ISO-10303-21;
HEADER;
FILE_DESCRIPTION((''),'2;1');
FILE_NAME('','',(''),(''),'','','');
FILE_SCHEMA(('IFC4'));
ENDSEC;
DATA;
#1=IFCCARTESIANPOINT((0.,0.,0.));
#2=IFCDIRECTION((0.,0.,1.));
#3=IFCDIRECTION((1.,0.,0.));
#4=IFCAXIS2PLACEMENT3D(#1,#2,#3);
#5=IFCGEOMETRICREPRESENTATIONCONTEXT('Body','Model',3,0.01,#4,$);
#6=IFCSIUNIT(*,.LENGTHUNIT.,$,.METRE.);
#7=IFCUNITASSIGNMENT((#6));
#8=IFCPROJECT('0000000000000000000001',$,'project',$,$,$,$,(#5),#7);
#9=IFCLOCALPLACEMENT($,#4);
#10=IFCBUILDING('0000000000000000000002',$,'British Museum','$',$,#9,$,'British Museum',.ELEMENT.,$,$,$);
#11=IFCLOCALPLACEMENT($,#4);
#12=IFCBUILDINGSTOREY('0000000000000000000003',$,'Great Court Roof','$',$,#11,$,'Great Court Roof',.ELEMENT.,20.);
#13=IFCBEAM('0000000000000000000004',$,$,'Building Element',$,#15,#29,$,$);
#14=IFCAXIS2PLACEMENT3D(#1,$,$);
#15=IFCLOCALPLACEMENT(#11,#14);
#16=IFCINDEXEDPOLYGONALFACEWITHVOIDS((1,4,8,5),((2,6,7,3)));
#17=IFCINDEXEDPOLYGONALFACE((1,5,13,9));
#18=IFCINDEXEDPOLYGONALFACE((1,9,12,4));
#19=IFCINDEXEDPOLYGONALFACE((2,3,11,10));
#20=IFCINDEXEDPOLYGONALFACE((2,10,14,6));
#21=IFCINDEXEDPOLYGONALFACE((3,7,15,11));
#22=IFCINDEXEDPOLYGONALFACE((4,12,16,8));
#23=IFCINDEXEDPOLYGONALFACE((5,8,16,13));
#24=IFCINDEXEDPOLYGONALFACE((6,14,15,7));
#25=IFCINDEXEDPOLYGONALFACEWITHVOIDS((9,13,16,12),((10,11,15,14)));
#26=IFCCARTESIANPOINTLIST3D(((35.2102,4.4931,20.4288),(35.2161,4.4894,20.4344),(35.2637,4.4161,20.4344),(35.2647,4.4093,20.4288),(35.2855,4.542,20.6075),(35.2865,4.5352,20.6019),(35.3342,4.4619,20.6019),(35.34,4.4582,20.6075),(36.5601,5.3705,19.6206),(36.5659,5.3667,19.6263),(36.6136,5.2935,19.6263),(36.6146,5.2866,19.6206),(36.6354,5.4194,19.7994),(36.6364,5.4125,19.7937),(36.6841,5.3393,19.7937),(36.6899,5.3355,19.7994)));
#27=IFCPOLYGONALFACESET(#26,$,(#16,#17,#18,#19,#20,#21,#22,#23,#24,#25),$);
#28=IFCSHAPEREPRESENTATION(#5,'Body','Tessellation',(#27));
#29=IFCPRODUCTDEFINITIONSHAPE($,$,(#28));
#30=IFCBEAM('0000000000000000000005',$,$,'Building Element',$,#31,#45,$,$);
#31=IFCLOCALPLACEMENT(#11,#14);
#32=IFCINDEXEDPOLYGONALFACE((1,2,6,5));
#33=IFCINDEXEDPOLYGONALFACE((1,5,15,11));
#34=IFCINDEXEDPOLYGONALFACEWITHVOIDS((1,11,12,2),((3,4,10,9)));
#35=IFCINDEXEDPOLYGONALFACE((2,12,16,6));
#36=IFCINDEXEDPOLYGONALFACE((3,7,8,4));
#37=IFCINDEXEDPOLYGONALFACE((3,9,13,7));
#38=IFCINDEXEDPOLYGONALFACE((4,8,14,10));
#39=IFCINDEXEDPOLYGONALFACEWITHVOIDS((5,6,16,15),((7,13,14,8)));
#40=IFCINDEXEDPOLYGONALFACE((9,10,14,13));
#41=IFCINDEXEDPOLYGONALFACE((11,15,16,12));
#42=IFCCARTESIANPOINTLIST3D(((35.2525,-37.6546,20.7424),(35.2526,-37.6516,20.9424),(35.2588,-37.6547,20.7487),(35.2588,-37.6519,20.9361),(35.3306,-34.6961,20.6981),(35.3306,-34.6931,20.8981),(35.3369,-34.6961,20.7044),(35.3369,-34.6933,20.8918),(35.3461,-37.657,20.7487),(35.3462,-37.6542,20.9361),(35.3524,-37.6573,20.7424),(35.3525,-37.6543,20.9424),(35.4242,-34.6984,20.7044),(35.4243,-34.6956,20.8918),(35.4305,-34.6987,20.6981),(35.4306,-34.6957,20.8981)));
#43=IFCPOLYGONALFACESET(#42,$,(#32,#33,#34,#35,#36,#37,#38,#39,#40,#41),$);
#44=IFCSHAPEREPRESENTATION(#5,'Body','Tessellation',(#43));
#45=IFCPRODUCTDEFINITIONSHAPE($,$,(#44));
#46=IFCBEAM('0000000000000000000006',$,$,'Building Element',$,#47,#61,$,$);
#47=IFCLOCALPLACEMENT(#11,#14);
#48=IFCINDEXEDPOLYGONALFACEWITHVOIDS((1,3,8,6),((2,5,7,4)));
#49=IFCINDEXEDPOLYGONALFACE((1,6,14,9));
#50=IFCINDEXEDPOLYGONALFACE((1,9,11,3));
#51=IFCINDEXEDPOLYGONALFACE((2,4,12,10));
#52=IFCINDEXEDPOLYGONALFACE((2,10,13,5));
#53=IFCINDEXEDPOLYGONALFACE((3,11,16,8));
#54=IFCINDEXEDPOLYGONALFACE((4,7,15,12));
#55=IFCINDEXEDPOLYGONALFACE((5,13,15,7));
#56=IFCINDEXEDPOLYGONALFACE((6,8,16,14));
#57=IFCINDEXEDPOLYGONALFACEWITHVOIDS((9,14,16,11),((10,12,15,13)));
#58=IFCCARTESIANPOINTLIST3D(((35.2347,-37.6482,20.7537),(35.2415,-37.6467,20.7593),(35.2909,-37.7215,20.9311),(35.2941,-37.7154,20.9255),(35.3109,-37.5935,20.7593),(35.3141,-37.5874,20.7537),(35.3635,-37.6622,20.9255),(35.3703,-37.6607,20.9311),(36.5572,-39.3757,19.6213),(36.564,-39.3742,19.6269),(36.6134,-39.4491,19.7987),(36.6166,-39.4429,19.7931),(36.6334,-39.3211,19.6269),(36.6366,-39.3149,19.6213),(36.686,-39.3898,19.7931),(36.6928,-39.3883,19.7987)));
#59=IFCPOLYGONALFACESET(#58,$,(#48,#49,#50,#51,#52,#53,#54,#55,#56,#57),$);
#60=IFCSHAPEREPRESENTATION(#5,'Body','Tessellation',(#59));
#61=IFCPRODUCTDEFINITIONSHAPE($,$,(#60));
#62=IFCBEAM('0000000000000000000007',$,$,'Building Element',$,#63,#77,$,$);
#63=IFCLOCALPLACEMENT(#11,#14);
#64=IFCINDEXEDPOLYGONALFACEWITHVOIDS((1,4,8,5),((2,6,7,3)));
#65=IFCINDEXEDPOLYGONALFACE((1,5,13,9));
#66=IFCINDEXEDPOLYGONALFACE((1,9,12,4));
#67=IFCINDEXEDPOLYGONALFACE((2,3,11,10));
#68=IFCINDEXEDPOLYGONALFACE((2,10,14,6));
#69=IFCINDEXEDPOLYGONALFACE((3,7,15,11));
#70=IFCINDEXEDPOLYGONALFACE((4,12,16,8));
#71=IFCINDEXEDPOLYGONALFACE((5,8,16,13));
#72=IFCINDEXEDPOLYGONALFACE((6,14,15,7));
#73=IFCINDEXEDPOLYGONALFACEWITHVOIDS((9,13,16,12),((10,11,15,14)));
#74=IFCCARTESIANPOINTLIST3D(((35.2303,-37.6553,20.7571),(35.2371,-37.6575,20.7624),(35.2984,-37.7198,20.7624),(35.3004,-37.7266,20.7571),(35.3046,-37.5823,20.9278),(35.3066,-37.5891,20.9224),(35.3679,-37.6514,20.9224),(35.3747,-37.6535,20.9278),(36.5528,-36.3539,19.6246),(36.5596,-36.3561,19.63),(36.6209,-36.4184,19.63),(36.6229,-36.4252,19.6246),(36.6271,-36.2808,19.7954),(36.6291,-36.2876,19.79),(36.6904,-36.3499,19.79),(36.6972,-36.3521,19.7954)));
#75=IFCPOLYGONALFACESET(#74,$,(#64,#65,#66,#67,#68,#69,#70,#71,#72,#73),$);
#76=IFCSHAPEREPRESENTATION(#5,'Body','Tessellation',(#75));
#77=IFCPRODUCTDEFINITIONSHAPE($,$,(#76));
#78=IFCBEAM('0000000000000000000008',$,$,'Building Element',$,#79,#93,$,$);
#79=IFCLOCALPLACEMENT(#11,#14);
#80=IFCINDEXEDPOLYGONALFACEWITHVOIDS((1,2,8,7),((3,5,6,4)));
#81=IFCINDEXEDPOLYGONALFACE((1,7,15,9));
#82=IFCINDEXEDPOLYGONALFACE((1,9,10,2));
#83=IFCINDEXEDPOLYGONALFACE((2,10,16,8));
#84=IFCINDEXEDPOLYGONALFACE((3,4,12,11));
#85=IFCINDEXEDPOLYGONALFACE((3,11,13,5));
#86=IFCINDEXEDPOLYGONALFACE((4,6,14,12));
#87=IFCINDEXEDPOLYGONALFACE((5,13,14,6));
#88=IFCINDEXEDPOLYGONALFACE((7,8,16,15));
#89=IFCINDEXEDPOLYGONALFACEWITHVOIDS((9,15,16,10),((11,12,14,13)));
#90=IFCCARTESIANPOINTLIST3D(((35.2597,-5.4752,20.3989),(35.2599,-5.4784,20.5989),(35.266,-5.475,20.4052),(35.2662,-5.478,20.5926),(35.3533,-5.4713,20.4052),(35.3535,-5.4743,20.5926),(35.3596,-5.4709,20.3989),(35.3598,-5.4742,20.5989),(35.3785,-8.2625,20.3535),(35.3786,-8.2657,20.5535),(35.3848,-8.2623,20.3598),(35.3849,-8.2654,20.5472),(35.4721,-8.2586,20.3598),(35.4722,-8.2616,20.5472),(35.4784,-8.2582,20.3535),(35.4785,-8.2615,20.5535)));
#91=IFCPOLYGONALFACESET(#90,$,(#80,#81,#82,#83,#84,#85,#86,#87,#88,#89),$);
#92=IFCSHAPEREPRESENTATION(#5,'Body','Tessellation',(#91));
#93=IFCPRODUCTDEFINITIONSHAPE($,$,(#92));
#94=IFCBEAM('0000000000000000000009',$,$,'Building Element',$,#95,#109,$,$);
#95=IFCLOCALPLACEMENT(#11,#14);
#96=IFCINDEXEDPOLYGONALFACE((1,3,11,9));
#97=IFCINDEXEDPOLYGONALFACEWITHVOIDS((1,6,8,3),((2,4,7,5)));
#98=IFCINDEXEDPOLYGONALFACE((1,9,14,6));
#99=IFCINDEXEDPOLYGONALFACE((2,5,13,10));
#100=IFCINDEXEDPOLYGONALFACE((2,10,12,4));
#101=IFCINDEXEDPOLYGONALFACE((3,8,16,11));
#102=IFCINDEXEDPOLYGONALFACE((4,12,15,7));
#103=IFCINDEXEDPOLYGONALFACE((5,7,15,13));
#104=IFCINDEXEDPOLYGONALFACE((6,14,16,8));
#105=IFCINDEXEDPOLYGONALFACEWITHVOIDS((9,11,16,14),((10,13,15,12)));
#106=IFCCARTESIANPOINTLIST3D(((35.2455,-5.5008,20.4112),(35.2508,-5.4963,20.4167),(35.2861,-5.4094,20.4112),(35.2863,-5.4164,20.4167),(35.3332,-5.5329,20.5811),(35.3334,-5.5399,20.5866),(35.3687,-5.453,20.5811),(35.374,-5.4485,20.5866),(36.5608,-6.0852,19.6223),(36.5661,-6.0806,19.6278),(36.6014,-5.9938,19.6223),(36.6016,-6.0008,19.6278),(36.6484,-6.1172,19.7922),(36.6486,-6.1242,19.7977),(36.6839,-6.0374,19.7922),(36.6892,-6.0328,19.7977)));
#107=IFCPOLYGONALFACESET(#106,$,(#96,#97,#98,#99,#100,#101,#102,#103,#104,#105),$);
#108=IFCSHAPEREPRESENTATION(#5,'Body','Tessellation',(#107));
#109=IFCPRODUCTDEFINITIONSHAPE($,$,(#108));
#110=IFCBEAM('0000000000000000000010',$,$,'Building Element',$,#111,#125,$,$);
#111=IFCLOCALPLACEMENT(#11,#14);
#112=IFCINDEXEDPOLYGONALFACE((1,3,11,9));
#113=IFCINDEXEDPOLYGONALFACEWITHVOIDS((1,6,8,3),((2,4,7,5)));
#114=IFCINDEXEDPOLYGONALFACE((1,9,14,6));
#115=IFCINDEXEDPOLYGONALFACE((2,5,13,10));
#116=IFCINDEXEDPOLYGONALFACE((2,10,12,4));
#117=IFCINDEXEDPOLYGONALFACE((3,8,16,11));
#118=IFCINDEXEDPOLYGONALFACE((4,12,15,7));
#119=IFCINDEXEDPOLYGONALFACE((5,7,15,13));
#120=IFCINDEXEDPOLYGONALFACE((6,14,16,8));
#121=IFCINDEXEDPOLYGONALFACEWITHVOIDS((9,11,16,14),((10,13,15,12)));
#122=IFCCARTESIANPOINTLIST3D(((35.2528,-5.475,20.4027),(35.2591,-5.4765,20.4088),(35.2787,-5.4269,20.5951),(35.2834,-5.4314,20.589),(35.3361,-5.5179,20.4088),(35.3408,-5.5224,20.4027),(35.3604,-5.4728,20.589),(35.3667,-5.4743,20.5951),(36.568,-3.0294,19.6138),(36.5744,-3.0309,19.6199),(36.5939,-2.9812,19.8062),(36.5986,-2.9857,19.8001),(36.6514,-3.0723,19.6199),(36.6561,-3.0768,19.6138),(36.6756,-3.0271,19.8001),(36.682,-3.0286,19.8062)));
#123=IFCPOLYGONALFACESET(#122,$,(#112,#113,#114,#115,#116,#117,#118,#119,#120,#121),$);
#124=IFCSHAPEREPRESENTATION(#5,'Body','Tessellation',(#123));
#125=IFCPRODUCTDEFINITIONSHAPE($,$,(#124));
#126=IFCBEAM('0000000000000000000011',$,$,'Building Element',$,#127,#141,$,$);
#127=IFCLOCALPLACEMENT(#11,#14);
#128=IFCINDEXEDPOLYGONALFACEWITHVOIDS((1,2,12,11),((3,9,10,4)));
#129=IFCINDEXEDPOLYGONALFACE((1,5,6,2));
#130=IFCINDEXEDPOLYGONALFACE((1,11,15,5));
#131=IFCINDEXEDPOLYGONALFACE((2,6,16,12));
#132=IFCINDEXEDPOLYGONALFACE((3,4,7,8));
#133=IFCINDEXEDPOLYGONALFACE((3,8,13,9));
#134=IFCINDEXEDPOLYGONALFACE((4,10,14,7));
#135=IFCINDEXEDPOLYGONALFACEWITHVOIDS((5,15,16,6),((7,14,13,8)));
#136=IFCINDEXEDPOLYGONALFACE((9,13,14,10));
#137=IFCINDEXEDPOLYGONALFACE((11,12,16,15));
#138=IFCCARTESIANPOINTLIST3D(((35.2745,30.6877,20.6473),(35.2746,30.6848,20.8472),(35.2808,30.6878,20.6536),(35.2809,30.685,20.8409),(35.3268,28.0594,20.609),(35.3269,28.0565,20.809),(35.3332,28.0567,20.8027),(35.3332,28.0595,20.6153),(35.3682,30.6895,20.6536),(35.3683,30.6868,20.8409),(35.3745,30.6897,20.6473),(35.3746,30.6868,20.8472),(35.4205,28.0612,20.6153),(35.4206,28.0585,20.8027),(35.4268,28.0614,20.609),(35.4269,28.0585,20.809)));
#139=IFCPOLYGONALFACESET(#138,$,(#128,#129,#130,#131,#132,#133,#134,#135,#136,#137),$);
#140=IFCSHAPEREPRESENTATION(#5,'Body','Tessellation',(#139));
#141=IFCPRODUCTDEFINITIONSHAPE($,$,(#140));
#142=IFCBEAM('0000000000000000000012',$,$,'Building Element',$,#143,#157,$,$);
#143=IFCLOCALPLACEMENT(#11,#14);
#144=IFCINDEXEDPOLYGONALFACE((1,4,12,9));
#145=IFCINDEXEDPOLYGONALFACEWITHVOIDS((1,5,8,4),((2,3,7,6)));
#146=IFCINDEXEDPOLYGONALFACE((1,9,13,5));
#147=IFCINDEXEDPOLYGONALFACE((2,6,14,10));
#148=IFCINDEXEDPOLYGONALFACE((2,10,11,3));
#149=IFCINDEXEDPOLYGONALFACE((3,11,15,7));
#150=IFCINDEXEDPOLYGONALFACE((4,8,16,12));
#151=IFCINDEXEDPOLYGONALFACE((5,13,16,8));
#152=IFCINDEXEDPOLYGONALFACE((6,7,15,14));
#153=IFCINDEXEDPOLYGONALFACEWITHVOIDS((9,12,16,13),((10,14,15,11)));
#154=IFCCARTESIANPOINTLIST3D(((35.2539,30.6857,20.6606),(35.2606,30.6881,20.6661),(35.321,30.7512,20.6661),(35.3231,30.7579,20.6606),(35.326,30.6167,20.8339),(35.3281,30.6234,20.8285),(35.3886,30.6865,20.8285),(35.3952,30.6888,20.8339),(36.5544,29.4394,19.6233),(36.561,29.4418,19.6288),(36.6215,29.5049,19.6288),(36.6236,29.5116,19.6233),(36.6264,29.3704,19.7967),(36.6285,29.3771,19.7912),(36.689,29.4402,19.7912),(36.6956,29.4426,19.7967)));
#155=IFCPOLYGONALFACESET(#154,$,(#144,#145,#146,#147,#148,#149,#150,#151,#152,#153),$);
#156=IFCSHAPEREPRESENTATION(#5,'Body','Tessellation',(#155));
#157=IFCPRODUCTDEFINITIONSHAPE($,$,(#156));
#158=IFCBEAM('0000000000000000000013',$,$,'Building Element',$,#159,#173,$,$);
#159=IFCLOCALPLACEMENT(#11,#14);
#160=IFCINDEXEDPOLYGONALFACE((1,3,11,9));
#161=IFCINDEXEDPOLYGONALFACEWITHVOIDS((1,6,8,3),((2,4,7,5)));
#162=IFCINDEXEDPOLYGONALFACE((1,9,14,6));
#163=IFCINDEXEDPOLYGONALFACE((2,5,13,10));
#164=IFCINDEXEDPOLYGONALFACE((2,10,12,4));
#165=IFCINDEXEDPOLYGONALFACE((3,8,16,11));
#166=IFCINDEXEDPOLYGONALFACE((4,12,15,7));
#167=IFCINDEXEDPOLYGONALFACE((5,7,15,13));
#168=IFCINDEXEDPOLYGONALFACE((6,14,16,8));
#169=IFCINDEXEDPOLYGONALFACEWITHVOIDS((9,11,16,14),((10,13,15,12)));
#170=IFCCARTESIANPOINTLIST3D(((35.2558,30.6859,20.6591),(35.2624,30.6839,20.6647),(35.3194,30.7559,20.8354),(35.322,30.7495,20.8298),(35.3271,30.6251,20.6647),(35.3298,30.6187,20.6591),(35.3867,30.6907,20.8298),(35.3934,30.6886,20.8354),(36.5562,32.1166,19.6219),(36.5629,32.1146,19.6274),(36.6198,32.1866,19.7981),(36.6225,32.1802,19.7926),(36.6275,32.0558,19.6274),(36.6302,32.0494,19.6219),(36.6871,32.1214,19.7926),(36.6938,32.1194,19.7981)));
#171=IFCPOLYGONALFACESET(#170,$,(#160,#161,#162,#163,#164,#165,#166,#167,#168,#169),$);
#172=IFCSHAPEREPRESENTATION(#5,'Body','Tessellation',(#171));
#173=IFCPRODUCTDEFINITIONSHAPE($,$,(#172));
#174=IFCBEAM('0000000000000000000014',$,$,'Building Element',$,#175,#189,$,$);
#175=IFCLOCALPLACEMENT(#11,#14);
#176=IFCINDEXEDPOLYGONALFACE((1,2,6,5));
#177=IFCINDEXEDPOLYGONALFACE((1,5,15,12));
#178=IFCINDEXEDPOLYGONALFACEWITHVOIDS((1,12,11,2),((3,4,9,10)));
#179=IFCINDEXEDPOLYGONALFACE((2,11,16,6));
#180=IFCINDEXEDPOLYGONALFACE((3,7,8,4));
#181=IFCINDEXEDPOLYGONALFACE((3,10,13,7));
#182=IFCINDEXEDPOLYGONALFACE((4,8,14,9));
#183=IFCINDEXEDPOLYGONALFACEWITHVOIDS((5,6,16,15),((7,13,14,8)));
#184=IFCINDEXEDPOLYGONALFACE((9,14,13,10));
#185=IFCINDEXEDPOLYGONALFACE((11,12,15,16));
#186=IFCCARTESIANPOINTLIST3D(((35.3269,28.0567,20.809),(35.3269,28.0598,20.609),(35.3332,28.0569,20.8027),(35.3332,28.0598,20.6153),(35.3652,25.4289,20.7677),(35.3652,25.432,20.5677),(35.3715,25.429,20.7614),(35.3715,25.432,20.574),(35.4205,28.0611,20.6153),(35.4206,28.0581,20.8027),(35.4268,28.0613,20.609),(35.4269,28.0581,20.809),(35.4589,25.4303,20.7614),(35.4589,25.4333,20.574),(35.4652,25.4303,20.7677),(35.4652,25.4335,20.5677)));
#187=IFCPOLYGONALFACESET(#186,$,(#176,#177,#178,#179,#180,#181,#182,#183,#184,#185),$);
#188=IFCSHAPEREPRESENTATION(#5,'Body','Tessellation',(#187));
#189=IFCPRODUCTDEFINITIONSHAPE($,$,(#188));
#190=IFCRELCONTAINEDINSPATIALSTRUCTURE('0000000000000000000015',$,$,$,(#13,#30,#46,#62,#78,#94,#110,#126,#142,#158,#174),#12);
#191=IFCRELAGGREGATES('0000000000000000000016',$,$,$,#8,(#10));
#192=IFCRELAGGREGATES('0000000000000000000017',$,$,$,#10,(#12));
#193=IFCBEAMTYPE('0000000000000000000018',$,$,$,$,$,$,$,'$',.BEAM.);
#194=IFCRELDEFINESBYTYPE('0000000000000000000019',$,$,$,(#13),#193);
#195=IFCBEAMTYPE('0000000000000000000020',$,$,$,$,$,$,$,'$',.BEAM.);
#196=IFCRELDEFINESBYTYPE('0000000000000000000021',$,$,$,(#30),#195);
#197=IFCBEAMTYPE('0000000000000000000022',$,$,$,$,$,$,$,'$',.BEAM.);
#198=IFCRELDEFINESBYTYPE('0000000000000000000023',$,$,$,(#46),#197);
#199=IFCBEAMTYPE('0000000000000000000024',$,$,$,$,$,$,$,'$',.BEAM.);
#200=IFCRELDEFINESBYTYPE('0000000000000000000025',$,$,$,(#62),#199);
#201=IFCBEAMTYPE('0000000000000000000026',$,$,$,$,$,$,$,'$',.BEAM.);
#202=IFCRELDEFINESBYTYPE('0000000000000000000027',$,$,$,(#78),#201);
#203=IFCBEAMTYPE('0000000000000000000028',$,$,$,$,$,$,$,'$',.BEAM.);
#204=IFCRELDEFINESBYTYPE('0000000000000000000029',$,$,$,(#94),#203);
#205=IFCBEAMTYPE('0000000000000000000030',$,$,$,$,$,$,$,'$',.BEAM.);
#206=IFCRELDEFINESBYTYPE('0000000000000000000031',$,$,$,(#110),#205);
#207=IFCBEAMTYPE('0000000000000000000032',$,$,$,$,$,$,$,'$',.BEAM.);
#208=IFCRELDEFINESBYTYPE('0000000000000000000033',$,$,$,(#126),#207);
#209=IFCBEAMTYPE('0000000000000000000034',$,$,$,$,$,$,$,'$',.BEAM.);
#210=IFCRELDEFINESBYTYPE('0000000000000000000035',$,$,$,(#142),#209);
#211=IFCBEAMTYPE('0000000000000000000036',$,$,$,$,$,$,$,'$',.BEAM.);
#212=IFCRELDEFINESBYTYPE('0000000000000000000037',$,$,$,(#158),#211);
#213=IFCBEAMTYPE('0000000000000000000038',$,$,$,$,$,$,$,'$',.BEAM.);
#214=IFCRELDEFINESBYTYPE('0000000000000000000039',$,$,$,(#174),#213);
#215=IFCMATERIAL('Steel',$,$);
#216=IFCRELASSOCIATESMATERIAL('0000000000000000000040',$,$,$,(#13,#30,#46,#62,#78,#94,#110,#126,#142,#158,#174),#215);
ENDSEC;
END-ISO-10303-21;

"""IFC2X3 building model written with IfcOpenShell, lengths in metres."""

from ifc_helpers import new_model, si_unit, frame, origin_with_axes, origin_2d, place, context, project, spatial, hollow_rectangle, extrude, material, type_object, element, save


model = new_model("IFC2X3")

# Units and contexts
model_context = context("Model", 3, precision=0.01, world=origin_with_axes(), identifier="Body")
ifc_project = project(units=[si_unit("LENGTHUNIT", "METRE")], contexts=[model_context])

# Building, storey
building_placement = place(None, origin_with_axes())
building = spatial("IfcBuilding", under=ifc_project, at=building_placement, Name="British Museum", Description="$", LongName="British Museum", CompositionType="ELEMENT")
storey_placement = place(None, origin_with_axes())
storey = spatial("IfcBuildingStorey", under=building, at=storey_placement, Name="Great Court Roof", Description="$", LongName="Great Court Roof", CompositionType="ELEMENT", Elevation=20.0)

# Beams
ifc_material = material(Name="Steel")
beam_type_1 = type_object("IfcBeamType", ElementType="$", PredefinedType="BEAM")
beam_1_placement = place(None, origin_with_axes())
element("IfcBeam", 1, at=beam_1_placement, inside=storey, type_object=beam_type_1, material=ifc_material, Description="Building Element", context=model_context, shape_type="SweptSolid", body=[
    extrude(hollow_rectangle(XDim=0.1, YDim=0.2, WallThickness=0.0063, InnerFilletRadius=0.0, OuterFilletRadius=0.0, at=origin_2d()), frame((35.2751, 4.4756, 20.5181), z_axis=(0.749354, 0.48705, -0.44861), x_axis=(-0.544965, 0.838459, 0.0)), (0.0, 0.0, 1.0), 1.8014),
])
beam_type_2 = type_object("IfcBeamType", ElementType="$", PredefinedType="BEAM")
beam_2_placement = place(None, origin_with_axes())
element("IfcBeam", 2, at=beam_2_placement, inside=storey, type_object=beam_type_2, material=ifc_material, Description="Building Element", context=model_context, shape_type="SweptSolid", body=[
    extrude(hollow_rectangle(XDim=0.1, YDim=0.2, WallThickness=0.0063, InnerFilletRadius=0.0, OuterFilletRadius=0.0, at=origin_2d()), frame((35.3025, -37.6544, 20.8424), z_axis=(0.026381, 0.99954, -0.014987), x_axis=(-0.999652, 0.026384, 0.0)), (0.0, 0.0, 1.0), 2.9599),
])
beam_type_3 = type_object("IfcBeamType", ElementType="$", PredefinedType="BEAM")
beam_3_placement = place(None, origin_with_axes())
element("IfcBeam", 3, at=beam_3_placement, inside=storey, type_object=beam_type_3, material=ifc_material, Description="Building Element", context=model_context, shape_type="SweptSolid", body=[
    extrude(hollow_rectangle(XDim=0.1, YDim=0.2, WallThickness=0.0063, InnerFilletRadius=0.0, OuterFilletRadius=0.0, at=origin_2d()), frame((35.3025, -37.6544, 20.8424), z_axis=(0.539199, -0.704341, -0.461701), x_axis=(0.794039, 0.607866, 0.0)), (0.0, 0.0, 1.0), 2.4527),
])
beam_type_4 = type_object("IfcBeamType", ElementType="$", PredefinedType="BEAM")
beam_4_placement = place(None, origin_with_axes())
element("IfcBeam", 4, at=beam_4_placement, inside=storey, type_object=beam_type_4, material=ifc_material, Description="Building Element", context=model_context, shape_type="SweptSolid", body=[
    extrude(hollow_rectangle(XDim=0.1, YDim=0.2, WallThickness=0.0063, InnerFilletRadius=0.0, OuterFilletRadius=0.0, at=origin_2d()), frame((35.3025, -37.6544, 20.8424), z_axis=(0.6084, 0.598711, -0.520956), x_axis=(-0.701409, 0.712759, 0.0)), (0.0, 0.0, 1.0), 2.1737),
])
beam_type_5 = type_object("IfcBeamType", ElementType="$", PredefinedType="BEAM")
beam_5_placement = place(None, origin_with_axes())
element("IfcBeam", 5, at=beam_5_placement, inside=storey, type_object=beam_type_5, material=ifc_material, Description="Building Element", context=model_context, shape_type="SweptSolid", body=[
    extrude(hollow_rectangle(XDim=0.1, YDim=0.2, WallThickness=0.0063, InnerFilletRadius=0.0, OuterFilletRadius=0.0, at=origin_2d()), frame((35.3098, -5.4747, 20.4989), z_axis=(0.042556, -0.998961, -0.016288), x_axis=(0.999094, 0.042562, 0.0)), (0.0, 0.0, 1.0), 2.7902),
])
beam_type_6 = type_object("IfcBeamType", ElementType="$", PredefinedType="BEAM")
beam_6_placement = place(None, origin_with_axes())
element("IfcBeam", 6, at=beam_6_placement, inside=storey, type_object=beam_type_6, material=ifc_material, Description="Building Element", context=model_context, shape_type="SweptSolid", body=[
    extrude(hollow_rectangle(XDim=0.1, YDim=0.2, WallThickness=0.0063, InnerFilletRadius=0.0, OuterFilletRadius=0.0, at=origin_2d()), frame((35.3098, -5.4747, 20.4989), z_axis=(0.801367, -0.356033, -0.480678), x_axis=(0.406015, 0.913867, 0.0)), (0.0, 0.0, 1.0), 1.6413),
])
beam_type_7 = type_object("IfcBeamType", ElementType="$", PredefinedType="BEAM")
beam_7_placement = place(None, origin_with_axes())
element("IfcBeam", 7, at=beam_7_placement, inside=storey, type_object=beam_type_7, material=ifc_material, Description="Building Element", context=model_context, shape_type="SweptSolid", body=[
    extrude(hollow_rectangle(XDim=0.1, YDim=0.2, WallThickness=0.0063, InnerFilletRadius=0.0, OuterFilletRadius=0.0, at=origin_2d()), frame((35.3098, -5.4747, 20.4989), z_axis=(0.455611, 0.847192, -0.273286), x_axis=(-0.880718, 0.473641, 0.0)), (0.0, 0.0, 1.0), 2.8868),
])
beam_type_8 = type_object("IfcBeamType", ElementType="$", PredefinedType="BEAM")
beam_8_placement = place(None, origin_with_axes())
element("IfcBeam", 8, at=beam_8_placement, inside=storey, type_object=beam_type_8, material=ifc_material, Description="Building Element", context=model_context, shape_type="SweptSolid", body=[
    extrude(hollow_rectangle(XDim=0.1, YDim=0.2, WallThickness=0.0063, InnerFilletRadius=0.0, OuterFilletRadius=0.0, at=origin_2d()), frame((35.3246, 30.6873, 20.7473), z_axis=(0.019898, -0.999696, -0.014537), x_axis=(0.999802, 0.0199, 0.0)), (0.0, 0.0, 1.0), 2.6291),
])
beam_type_9 = type_object("IfcBeamType", ElementType="$", PredefinedType="BEAM")
beam_9_placement = place(None, origin_with_axes())
element("IfcBeam", 9, at=beam_9_placement, inside=storey, type_object=beam_type_9, material=ifc_material, Description="Building Element", context=model_context, shape_type="SweptSolid", body=[
    extrude(hollow_rectangle(XDim=0.1, YDim=0.2, WallThickness=0.0063, InnerFilletRadius=0.0, OuterFilletRadius=0.0, at=origin_2d()), frame((35.3246, 30.6873, 20.7473), z_axis=(0.625658, -0.599598, -0.499033), x_axis=(0.691911, 0.721983, 0.0)), (0.0, 0.0, 1.0), 2.0785),
])
beam_type_10 = type_object("IfcBeamType", ElementType="$", PredefinedType="BEAM")
beam_10_placement = place(None, origin_with_axes())
element("IfcBeam", 10, at=beam_10_placement, inside=storey, type_object=beam_type_10, material=ifc_material, Description="Building Element", context=model_context, shape_type="SweptSolid", body=[
    extrude(hollow_rectangle(XDim=0.1, YDim=0.2, WallThickness=0.0063, InnerFilletRadius=0.0, OuterFilletRadius=0.0, at=origin_2d()), frame((35.3246, 30.6873, 20.7473), z_axis=(0.592705, 0.65208, -0.472749), x_axis=(-0.739994, 0.672613, 0.0)), (0.0, 0.0, 1.0), 2.1941),
])
beam_type_11 = type_object("IfcBeamType", ElementType="$", PredefinedType="BEAM")
beam_11_placement = place(None, origin_with_axes())
element("IfcBeam", 11, at=beam_11_placement, inside=storey, type_object=beam_type_11, material=ifc_material, Description="Building Element", context=model_context, shape_type="SweptSolid", body=[
    extrude(hollow_rectangle(XDim=0.1, YDim=0.2, WallThickness=0.0063, InnerFilletRadius=0.0, OuterFilletRadius=0.0, at=origin_2d()), frame((35.3769, 28.059, 20.709), z_axis=(0.014584, -0.99977, -0.015727), x_axis=(0.999894, 0.014586, 0.0)), (0.0, 0.0, 1.0), 2.6284),
])

save(model, "model.ifc")
